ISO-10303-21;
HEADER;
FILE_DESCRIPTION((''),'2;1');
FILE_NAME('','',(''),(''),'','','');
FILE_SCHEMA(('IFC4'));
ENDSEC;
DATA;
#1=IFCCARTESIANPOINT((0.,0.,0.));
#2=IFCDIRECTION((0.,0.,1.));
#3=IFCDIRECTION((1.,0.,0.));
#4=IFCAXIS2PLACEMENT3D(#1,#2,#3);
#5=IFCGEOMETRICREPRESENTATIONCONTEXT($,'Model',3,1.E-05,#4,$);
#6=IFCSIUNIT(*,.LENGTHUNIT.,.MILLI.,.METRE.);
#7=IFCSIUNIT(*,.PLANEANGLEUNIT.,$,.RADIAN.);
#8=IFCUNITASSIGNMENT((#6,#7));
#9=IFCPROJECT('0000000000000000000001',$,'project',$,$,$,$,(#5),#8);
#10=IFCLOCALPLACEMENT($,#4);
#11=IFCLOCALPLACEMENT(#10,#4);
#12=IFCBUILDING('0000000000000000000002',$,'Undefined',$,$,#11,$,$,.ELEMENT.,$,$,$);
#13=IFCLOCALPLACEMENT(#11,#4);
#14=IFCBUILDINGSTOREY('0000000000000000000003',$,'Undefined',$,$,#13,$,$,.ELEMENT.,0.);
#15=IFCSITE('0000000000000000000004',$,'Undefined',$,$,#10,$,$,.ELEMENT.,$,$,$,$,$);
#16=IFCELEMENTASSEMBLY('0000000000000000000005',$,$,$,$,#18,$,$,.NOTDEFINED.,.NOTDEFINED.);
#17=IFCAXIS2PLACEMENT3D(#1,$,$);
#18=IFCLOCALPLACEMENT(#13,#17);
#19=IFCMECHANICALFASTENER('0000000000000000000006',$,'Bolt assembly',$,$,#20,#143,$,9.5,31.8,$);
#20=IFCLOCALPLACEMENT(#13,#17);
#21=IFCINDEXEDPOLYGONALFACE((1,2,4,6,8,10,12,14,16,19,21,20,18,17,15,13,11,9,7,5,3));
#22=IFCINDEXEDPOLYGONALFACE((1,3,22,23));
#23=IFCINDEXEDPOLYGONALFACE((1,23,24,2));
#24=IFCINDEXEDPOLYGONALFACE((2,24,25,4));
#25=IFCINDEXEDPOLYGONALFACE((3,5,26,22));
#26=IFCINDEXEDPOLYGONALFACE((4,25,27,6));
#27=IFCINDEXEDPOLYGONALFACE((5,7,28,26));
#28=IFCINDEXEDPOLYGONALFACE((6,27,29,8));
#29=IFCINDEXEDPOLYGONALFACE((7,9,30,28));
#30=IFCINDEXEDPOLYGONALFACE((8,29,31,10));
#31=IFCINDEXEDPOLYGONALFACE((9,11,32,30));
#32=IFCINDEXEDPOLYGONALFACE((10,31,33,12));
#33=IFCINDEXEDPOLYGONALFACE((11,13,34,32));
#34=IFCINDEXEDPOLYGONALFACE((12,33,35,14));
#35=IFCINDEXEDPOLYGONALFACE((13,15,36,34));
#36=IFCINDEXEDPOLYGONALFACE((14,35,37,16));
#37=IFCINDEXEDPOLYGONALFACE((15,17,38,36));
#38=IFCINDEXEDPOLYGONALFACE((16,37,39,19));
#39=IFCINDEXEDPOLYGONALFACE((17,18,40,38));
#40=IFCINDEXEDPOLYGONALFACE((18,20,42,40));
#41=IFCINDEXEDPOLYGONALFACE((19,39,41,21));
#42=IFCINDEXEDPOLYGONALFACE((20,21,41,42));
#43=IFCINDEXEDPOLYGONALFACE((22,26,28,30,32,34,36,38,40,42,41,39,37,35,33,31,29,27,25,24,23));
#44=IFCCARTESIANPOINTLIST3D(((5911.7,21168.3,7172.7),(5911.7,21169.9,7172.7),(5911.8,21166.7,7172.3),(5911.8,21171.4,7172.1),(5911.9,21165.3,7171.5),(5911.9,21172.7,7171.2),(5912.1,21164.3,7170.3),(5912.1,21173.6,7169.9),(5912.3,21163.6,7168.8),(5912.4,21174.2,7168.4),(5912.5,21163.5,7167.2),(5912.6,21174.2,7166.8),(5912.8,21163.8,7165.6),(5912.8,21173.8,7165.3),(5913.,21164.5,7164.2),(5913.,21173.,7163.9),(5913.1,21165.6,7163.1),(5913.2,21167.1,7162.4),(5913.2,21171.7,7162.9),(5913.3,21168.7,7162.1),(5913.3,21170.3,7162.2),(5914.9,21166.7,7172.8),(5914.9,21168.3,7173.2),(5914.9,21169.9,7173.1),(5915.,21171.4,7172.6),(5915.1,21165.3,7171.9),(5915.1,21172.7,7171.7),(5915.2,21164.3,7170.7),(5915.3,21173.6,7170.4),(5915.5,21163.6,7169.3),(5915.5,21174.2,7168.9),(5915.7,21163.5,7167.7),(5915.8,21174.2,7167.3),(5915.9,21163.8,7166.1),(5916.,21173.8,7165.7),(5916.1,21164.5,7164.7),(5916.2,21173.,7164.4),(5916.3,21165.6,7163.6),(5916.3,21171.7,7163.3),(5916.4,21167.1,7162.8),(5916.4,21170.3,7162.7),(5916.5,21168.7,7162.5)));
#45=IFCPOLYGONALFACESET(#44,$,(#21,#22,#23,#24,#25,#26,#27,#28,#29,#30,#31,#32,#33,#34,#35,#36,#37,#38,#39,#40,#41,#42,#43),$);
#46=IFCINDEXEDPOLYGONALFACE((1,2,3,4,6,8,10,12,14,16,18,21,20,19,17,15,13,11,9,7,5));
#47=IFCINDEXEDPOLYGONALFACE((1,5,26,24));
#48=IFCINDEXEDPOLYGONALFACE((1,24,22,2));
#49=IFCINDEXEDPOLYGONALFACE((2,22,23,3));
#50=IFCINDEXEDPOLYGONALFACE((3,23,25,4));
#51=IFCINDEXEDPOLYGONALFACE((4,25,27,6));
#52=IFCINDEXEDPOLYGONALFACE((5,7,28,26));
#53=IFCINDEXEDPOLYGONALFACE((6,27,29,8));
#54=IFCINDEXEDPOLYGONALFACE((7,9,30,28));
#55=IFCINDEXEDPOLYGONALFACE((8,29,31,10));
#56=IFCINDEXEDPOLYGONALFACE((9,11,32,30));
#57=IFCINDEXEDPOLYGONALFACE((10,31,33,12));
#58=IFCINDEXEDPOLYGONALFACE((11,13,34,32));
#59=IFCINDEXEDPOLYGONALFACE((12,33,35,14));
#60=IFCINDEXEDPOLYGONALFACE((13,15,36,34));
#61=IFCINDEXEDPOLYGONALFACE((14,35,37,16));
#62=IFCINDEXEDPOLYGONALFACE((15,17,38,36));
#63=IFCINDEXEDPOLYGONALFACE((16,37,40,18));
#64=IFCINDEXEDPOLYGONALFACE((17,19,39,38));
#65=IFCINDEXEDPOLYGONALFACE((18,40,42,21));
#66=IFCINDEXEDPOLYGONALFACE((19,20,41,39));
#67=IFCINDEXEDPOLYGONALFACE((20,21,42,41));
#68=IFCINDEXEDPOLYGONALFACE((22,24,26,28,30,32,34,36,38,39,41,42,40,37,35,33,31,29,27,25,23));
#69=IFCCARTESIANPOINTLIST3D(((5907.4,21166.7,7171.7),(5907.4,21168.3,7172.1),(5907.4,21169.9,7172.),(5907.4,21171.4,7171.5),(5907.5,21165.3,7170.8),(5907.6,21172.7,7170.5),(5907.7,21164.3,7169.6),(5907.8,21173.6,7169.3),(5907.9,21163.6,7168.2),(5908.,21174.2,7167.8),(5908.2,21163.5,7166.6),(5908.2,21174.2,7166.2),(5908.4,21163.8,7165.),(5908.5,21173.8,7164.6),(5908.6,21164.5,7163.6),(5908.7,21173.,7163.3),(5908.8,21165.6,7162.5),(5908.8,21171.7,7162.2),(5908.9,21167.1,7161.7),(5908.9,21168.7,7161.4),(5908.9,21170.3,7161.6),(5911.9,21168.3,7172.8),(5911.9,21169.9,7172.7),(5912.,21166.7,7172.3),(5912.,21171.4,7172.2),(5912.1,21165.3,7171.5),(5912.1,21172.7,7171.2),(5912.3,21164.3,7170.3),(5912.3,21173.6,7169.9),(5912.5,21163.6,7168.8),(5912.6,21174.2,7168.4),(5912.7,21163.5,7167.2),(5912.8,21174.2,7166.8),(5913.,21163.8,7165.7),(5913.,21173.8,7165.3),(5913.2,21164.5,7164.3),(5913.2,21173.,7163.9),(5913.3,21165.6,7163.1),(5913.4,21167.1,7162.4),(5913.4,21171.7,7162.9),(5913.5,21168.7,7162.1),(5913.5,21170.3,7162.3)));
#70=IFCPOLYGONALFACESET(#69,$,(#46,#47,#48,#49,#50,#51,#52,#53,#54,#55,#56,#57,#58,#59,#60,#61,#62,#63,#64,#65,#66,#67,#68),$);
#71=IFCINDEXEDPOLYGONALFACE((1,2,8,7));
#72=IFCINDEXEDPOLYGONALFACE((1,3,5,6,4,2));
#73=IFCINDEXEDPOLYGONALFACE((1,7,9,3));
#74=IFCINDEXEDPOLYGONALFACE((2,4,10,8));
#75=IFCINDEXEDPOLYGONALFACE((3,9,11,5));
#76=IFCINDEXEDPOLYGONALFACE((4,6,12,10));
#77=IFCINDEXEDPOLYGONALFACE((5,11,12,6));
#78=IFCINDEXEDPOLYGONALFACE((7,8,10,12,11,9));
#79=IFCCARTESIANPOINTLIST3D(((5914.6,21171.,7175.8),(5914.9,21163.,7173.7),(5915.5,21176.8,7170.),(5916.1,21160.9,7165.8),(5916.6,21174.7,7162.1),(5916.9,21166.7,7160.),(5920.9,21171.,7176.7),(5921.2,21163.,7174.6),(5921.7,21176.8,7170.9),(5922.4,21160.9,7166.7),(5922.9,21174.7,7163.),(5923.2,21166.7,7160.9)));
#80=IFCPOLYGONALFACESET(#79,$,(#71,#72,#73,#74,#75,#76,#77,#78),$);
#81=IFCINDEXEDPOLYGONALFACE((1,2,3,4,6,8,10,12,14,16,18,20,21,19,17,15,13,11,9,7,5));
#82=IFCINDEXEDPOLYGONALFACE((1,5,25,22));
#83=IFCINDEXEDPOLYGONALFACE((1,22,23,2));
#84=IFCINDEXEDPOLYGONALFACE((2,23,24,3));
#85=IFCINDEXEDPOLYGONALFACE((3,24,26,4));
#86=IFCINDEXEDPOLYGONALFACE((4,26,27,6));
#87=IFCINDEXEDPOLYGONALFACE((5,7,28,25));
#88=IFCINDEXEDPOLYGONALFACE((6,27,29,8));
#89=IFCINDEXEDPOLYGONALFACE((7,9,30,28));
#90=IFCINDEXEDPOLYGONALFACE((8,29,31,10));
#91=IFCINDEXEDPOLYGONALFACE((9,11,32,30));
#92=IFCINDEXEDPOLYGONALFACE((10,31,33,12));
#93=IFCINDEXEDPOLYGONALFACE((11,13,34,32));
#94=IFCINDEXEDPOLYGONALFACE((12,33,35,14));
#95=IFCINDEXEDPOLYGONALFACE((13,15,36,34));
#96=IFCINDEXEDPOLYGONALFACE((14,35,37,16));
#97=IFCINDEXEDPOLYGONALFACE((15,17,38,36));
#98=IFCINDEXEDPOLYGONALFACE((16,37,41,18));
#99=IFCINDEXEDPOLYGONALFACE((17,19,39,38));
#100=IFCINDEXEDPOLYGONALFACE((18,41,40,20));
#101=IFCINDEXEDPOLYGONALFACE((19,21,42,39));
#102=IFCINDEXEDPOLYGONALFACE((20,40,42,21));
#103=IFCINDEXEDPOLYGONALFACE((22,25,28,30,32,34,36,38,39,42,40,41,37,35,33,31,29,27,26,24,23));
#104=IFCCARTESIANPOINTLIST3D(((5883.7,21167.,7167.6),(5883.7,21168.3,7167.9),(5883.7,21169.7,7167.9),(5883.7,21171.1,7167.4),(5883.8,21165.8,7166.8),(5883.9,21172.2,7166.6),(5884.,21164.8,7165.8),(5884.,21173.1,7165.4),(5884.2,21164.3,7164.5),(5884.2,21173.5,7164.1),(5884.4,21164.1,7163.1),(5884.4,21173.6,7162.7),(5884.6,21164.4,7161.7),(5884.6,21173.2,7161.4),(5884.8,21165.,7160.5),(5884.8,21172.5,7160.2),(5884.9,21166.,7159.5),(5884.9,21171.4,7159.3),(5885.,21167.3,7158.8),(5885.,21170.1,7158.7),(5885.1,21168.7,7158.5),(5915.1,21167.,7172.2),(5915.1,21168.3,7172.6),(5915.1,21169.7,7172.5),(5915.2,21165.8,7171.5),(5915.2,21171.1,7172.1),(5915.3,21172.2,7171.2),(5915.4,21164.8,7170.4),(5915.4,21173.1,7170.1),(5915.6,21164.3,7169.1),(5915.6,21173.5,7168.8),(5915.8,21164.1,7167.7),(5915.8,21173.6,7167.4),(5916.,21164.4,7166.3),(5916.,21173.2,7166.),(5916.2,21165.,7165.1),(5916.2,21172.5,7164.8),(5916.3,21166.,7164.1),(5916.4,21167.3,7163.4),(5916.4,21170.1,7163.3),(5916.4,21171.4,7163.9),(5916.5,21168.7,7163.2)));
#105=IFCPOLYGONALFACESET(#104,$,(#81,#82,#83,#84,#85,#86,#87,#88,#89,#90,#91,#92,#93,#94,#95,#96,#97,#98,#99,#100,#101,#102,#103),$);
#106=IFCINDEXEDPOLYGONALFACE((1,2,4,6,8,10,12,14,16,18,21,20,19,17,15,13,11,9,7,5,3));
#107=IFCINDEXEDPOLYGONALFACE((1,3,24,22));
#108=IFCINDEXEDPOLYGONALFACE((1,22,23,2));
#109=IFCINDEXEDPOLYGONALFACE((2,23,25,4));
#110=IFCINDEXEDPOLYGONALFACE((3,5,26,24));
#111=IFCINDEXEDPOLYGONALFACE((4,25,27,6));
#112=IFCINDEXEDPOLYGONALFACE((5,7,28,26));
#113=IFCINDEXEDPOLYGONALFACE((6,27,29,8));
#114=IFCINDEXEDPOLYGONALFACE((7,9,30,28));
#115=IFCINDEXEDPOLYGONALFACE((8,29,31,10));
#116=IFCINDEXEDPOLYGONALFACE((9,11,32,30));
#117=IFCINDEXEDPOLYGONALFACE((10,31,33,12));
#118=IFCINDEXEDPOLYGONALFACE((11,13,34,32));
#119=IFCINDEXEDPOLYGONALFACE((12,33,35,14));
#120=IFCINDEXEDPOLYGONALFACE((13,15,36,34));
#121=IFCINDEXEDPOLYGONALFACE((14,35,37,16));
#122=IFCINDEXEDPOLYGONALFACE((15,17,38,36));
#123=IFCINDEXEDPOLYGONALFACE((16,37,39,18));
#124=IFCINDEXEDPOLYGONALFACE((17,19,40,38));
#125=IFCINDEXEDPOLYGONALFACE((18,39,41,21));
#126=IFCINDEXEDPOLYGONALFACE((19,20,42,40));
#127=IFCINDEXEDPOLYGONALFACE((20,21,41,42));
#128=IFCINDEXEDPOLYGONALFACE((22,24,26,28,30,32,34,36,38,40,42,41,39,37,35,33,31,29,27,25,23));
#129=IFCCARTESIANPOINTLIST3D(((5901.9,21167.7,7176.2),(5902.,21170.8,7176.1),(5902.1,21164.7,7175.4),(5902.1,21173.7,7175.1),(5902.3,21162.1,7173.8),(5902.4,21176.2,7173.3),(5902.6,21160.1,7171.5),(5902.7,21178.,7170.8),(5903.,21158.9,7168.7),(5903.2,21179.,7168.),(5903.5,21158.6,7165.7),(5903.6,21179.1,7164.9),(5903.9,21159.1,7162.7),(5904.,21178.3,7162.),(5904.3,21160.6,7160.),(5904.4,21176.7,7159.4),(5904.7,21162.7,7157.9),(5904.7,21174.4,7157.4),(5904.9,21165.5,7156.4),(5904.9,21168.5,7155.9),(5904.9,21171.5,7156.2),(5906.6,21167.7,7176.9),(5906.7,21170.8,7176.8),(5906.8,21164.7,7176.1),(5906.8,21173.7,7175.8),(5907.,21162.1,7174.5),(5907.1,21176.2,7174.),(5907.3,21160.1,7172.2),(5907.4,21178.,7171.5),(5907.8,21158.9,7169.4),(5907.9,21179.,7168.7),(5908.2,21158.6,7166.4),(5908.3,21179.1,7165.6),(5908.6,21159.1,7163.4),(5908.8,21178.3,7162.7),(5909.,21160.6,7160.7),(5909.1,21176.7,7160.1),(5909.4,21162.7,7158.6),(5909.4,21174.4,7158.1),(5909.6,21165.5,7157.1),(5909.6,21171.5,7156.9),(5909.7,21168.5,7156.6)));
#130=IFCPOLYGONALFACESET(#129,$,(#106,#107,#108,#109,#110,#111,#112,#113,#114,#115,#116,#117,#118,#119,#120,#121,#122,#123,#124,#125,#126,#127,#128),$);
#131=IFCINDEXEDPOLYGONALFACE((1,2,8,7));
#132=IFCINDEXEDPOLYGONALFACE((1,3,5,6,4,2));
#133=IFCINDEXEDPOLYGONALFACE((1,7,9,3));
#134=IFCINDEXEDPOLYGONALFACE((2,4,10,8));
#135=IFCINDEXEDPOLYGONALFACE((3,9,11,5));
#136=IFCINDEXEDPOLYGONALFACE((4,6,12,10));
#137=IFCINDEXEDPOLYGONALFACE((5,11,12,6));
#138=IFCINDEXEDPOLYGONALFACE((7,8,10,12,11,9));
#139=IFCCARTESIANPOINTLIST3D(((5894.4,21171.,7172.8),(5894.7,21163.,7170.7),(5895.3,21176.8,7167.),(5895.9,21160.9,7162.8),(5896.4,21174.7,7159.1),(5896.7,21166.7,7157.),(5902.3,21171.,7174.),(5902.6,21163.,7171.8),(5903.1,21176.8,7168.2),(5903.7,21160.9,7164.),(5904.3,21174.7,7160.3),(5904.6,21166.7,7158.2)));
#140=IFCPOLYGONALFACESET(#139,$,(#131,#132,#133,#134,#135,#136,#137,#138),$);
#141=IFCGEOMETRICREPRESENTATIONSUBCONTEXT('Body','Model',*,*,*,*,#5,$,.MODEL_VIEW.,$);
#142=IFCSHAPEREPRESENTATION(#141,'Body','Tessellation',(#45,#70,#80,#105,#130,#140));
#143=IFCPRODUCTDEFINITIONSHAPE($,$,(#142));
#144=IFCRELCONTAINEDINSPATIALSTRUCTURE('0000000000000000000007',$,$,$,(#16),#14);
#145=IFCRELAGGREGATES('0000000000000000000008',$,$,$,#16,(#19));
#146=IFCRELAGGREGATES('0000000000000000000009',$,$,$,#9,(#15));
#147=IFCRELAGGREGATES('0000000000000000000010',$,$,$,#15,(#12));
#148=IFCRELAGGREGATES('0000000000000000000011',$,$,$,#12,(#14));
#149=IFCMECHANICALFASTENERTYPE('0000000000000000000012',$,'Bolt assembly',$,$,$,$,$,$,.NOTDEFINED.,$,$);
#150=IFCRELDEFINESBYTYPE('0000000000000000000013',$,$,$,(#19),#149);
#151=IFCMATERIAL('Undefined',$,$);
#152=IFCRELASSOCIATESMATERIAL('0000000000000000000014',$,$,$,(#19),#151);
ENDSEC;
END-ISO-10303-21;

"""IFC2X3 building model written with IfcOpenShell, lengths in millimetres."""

from ifc_helpers import new_model, si_unit, frame, origin_with_axes, origin_2d_with_axis, place, context, subcontext, project, spatial, polyline, circle, outline, extrude, source, transform, mapped, material, type_object, element, aggregate, save


model = new_model("IFC2X3")

# Units and contexts
model_context = context("Model", 3, precision=1e-05, world=origin_with_axes())
body_context = subcontext(model_context, "Body", "Model", "MODEL_VIEW")
ifc_project = project(units=[si_unit("LENGTHUNIT", "METRE", prefix="MILLI"), si_unit("PLANEANGLEUNIT", "RADIAN")], contexts=[model_context])

# Site, building, storey
site_placement = place(None, origin_with_axes())
site = spatial("IfcSite", under=ifc_project, at=site_placement, Name="Undefined", CompositionType="ELEMENT")
building_placement = place(site_placement, origin_with_axes())
building = spatial("IfcBuilding", under=site, at=building_placement, Name="Undefined", CompositionType="ELEMENT")
storey_placement = place(building_placement, origin_with_axes())
storey = spatial("IfcBuildingStorey", under=building, at=storey_placement, Name="Undefined", CompositionType="ELEMENT", Elevation=0.0)

# Element assembly
assembly_1_placement = place(storey_placement, origin_with_axes())
assembly_1 = element("IfcElementAssembly", 1, at=assembly_1_placement, inside=storey, AssemblyPlace="NOTDEFINED", PredefinedType="NOTDEFINED")

# Shared definitions
ifc_material_1 = material(Name="Undefined")
mechanical_fastener_type = type_object("IfcMechanicalFastenerType", Name="Bolt assembly")

# Mechanical fastener
shared_shape_1 = source(origin_with_axes(), body_context, "Body", "SweptSolid", [
    extrude(circle(Radius=5.4, at=origin_2d_with_axis()), frame((0.0, -3.1, 0.0), z_axis=(0.0, 1.0, 0.0), x_axis=(1.0, 0.0, 0.0)), (0.0, 0.0, 1.0), 3.2),
    extrude(circle(Radius=5.4, at=origin_2d_with_axis()), frame((0.0, -0.1, 0.0), z_axis=(0.0, 1.0, 0.0), x_axis=(1.0, 0.0, 0.0)), (0.0, 0.0, 1.0), 4.6),
    extrude(outline(polyline([(7.1, -4.1), (7.1, 4.1), (0.0, 8.2), (-7.1, 4.1), (-7.1, -4.1), (0.0, -8.2), (7.1, -4.1)])), frame((0.0, -9.6, 0.0), z_axis=(0.0, 1.0, 0.0), x_axis=(1.0, 0.0, 0.0)), (0.0, 0.0, 1.0), 6.3),
    extrude(circle(Radius=4.8, at=origin_2d_with_axis()), frame((0.0, -3.2, 0.0), z_axis=(0.0, 1.0, 0.0), x_axis=(1.0, 0.0, 0.0)), (0.0, 0.0, 1.0), 31.8),
    extrude(circle(Radius=10.3, at=origin_2d_with_axis()), frame((0.0, 4.5, 0.0), z_axis=(0.0, 1.0, 0.0), x_axis=(1.0, 0.0, 0.0)), (0.0, 0.0, 1.0), 4.8),
    extrude(outline(polyline([(7.1, -4.1), (7.1, 4.1), (0.0, 8.2), (-7.1, 4.1), (-7.1, -4.1), (0.0, -8.2), (7.1, -4.1)])), frame((0.0, 9.3, 0.0), z_axis=(0.0, 1.0, 0.0), x_axis=(1.0, 0.0, 0.0)), (0.0, 0.0, 1.0), 7.9),
])
mechanical_fastener_1_placement = place(assembly_1_placement, frame((5912.6, 21168.9, 7167.4), z_axis=(-0.103381, -0.707107, 0.699509), x_axis=(-0.103381, 0.707107, 0.699509)))
mechanical_fastener_1 = element("IfcMechanicalFastener", 2, at=mechanical_fastener_1_placement, type_object=mechanical_fastener_type, material=ifc_material_1, Name="Bolt assembly", NominalDiameter=9.5, NominalLength=31.8, context=body_context, shape_type="MappedRepresentation", body=[
    mapped(shared_shape_1, transform((0.0, 0.0, 0.0))),
])
aggregate(assembly_1, [mechanical_fastener_1])

save(model, "model.ifc")
